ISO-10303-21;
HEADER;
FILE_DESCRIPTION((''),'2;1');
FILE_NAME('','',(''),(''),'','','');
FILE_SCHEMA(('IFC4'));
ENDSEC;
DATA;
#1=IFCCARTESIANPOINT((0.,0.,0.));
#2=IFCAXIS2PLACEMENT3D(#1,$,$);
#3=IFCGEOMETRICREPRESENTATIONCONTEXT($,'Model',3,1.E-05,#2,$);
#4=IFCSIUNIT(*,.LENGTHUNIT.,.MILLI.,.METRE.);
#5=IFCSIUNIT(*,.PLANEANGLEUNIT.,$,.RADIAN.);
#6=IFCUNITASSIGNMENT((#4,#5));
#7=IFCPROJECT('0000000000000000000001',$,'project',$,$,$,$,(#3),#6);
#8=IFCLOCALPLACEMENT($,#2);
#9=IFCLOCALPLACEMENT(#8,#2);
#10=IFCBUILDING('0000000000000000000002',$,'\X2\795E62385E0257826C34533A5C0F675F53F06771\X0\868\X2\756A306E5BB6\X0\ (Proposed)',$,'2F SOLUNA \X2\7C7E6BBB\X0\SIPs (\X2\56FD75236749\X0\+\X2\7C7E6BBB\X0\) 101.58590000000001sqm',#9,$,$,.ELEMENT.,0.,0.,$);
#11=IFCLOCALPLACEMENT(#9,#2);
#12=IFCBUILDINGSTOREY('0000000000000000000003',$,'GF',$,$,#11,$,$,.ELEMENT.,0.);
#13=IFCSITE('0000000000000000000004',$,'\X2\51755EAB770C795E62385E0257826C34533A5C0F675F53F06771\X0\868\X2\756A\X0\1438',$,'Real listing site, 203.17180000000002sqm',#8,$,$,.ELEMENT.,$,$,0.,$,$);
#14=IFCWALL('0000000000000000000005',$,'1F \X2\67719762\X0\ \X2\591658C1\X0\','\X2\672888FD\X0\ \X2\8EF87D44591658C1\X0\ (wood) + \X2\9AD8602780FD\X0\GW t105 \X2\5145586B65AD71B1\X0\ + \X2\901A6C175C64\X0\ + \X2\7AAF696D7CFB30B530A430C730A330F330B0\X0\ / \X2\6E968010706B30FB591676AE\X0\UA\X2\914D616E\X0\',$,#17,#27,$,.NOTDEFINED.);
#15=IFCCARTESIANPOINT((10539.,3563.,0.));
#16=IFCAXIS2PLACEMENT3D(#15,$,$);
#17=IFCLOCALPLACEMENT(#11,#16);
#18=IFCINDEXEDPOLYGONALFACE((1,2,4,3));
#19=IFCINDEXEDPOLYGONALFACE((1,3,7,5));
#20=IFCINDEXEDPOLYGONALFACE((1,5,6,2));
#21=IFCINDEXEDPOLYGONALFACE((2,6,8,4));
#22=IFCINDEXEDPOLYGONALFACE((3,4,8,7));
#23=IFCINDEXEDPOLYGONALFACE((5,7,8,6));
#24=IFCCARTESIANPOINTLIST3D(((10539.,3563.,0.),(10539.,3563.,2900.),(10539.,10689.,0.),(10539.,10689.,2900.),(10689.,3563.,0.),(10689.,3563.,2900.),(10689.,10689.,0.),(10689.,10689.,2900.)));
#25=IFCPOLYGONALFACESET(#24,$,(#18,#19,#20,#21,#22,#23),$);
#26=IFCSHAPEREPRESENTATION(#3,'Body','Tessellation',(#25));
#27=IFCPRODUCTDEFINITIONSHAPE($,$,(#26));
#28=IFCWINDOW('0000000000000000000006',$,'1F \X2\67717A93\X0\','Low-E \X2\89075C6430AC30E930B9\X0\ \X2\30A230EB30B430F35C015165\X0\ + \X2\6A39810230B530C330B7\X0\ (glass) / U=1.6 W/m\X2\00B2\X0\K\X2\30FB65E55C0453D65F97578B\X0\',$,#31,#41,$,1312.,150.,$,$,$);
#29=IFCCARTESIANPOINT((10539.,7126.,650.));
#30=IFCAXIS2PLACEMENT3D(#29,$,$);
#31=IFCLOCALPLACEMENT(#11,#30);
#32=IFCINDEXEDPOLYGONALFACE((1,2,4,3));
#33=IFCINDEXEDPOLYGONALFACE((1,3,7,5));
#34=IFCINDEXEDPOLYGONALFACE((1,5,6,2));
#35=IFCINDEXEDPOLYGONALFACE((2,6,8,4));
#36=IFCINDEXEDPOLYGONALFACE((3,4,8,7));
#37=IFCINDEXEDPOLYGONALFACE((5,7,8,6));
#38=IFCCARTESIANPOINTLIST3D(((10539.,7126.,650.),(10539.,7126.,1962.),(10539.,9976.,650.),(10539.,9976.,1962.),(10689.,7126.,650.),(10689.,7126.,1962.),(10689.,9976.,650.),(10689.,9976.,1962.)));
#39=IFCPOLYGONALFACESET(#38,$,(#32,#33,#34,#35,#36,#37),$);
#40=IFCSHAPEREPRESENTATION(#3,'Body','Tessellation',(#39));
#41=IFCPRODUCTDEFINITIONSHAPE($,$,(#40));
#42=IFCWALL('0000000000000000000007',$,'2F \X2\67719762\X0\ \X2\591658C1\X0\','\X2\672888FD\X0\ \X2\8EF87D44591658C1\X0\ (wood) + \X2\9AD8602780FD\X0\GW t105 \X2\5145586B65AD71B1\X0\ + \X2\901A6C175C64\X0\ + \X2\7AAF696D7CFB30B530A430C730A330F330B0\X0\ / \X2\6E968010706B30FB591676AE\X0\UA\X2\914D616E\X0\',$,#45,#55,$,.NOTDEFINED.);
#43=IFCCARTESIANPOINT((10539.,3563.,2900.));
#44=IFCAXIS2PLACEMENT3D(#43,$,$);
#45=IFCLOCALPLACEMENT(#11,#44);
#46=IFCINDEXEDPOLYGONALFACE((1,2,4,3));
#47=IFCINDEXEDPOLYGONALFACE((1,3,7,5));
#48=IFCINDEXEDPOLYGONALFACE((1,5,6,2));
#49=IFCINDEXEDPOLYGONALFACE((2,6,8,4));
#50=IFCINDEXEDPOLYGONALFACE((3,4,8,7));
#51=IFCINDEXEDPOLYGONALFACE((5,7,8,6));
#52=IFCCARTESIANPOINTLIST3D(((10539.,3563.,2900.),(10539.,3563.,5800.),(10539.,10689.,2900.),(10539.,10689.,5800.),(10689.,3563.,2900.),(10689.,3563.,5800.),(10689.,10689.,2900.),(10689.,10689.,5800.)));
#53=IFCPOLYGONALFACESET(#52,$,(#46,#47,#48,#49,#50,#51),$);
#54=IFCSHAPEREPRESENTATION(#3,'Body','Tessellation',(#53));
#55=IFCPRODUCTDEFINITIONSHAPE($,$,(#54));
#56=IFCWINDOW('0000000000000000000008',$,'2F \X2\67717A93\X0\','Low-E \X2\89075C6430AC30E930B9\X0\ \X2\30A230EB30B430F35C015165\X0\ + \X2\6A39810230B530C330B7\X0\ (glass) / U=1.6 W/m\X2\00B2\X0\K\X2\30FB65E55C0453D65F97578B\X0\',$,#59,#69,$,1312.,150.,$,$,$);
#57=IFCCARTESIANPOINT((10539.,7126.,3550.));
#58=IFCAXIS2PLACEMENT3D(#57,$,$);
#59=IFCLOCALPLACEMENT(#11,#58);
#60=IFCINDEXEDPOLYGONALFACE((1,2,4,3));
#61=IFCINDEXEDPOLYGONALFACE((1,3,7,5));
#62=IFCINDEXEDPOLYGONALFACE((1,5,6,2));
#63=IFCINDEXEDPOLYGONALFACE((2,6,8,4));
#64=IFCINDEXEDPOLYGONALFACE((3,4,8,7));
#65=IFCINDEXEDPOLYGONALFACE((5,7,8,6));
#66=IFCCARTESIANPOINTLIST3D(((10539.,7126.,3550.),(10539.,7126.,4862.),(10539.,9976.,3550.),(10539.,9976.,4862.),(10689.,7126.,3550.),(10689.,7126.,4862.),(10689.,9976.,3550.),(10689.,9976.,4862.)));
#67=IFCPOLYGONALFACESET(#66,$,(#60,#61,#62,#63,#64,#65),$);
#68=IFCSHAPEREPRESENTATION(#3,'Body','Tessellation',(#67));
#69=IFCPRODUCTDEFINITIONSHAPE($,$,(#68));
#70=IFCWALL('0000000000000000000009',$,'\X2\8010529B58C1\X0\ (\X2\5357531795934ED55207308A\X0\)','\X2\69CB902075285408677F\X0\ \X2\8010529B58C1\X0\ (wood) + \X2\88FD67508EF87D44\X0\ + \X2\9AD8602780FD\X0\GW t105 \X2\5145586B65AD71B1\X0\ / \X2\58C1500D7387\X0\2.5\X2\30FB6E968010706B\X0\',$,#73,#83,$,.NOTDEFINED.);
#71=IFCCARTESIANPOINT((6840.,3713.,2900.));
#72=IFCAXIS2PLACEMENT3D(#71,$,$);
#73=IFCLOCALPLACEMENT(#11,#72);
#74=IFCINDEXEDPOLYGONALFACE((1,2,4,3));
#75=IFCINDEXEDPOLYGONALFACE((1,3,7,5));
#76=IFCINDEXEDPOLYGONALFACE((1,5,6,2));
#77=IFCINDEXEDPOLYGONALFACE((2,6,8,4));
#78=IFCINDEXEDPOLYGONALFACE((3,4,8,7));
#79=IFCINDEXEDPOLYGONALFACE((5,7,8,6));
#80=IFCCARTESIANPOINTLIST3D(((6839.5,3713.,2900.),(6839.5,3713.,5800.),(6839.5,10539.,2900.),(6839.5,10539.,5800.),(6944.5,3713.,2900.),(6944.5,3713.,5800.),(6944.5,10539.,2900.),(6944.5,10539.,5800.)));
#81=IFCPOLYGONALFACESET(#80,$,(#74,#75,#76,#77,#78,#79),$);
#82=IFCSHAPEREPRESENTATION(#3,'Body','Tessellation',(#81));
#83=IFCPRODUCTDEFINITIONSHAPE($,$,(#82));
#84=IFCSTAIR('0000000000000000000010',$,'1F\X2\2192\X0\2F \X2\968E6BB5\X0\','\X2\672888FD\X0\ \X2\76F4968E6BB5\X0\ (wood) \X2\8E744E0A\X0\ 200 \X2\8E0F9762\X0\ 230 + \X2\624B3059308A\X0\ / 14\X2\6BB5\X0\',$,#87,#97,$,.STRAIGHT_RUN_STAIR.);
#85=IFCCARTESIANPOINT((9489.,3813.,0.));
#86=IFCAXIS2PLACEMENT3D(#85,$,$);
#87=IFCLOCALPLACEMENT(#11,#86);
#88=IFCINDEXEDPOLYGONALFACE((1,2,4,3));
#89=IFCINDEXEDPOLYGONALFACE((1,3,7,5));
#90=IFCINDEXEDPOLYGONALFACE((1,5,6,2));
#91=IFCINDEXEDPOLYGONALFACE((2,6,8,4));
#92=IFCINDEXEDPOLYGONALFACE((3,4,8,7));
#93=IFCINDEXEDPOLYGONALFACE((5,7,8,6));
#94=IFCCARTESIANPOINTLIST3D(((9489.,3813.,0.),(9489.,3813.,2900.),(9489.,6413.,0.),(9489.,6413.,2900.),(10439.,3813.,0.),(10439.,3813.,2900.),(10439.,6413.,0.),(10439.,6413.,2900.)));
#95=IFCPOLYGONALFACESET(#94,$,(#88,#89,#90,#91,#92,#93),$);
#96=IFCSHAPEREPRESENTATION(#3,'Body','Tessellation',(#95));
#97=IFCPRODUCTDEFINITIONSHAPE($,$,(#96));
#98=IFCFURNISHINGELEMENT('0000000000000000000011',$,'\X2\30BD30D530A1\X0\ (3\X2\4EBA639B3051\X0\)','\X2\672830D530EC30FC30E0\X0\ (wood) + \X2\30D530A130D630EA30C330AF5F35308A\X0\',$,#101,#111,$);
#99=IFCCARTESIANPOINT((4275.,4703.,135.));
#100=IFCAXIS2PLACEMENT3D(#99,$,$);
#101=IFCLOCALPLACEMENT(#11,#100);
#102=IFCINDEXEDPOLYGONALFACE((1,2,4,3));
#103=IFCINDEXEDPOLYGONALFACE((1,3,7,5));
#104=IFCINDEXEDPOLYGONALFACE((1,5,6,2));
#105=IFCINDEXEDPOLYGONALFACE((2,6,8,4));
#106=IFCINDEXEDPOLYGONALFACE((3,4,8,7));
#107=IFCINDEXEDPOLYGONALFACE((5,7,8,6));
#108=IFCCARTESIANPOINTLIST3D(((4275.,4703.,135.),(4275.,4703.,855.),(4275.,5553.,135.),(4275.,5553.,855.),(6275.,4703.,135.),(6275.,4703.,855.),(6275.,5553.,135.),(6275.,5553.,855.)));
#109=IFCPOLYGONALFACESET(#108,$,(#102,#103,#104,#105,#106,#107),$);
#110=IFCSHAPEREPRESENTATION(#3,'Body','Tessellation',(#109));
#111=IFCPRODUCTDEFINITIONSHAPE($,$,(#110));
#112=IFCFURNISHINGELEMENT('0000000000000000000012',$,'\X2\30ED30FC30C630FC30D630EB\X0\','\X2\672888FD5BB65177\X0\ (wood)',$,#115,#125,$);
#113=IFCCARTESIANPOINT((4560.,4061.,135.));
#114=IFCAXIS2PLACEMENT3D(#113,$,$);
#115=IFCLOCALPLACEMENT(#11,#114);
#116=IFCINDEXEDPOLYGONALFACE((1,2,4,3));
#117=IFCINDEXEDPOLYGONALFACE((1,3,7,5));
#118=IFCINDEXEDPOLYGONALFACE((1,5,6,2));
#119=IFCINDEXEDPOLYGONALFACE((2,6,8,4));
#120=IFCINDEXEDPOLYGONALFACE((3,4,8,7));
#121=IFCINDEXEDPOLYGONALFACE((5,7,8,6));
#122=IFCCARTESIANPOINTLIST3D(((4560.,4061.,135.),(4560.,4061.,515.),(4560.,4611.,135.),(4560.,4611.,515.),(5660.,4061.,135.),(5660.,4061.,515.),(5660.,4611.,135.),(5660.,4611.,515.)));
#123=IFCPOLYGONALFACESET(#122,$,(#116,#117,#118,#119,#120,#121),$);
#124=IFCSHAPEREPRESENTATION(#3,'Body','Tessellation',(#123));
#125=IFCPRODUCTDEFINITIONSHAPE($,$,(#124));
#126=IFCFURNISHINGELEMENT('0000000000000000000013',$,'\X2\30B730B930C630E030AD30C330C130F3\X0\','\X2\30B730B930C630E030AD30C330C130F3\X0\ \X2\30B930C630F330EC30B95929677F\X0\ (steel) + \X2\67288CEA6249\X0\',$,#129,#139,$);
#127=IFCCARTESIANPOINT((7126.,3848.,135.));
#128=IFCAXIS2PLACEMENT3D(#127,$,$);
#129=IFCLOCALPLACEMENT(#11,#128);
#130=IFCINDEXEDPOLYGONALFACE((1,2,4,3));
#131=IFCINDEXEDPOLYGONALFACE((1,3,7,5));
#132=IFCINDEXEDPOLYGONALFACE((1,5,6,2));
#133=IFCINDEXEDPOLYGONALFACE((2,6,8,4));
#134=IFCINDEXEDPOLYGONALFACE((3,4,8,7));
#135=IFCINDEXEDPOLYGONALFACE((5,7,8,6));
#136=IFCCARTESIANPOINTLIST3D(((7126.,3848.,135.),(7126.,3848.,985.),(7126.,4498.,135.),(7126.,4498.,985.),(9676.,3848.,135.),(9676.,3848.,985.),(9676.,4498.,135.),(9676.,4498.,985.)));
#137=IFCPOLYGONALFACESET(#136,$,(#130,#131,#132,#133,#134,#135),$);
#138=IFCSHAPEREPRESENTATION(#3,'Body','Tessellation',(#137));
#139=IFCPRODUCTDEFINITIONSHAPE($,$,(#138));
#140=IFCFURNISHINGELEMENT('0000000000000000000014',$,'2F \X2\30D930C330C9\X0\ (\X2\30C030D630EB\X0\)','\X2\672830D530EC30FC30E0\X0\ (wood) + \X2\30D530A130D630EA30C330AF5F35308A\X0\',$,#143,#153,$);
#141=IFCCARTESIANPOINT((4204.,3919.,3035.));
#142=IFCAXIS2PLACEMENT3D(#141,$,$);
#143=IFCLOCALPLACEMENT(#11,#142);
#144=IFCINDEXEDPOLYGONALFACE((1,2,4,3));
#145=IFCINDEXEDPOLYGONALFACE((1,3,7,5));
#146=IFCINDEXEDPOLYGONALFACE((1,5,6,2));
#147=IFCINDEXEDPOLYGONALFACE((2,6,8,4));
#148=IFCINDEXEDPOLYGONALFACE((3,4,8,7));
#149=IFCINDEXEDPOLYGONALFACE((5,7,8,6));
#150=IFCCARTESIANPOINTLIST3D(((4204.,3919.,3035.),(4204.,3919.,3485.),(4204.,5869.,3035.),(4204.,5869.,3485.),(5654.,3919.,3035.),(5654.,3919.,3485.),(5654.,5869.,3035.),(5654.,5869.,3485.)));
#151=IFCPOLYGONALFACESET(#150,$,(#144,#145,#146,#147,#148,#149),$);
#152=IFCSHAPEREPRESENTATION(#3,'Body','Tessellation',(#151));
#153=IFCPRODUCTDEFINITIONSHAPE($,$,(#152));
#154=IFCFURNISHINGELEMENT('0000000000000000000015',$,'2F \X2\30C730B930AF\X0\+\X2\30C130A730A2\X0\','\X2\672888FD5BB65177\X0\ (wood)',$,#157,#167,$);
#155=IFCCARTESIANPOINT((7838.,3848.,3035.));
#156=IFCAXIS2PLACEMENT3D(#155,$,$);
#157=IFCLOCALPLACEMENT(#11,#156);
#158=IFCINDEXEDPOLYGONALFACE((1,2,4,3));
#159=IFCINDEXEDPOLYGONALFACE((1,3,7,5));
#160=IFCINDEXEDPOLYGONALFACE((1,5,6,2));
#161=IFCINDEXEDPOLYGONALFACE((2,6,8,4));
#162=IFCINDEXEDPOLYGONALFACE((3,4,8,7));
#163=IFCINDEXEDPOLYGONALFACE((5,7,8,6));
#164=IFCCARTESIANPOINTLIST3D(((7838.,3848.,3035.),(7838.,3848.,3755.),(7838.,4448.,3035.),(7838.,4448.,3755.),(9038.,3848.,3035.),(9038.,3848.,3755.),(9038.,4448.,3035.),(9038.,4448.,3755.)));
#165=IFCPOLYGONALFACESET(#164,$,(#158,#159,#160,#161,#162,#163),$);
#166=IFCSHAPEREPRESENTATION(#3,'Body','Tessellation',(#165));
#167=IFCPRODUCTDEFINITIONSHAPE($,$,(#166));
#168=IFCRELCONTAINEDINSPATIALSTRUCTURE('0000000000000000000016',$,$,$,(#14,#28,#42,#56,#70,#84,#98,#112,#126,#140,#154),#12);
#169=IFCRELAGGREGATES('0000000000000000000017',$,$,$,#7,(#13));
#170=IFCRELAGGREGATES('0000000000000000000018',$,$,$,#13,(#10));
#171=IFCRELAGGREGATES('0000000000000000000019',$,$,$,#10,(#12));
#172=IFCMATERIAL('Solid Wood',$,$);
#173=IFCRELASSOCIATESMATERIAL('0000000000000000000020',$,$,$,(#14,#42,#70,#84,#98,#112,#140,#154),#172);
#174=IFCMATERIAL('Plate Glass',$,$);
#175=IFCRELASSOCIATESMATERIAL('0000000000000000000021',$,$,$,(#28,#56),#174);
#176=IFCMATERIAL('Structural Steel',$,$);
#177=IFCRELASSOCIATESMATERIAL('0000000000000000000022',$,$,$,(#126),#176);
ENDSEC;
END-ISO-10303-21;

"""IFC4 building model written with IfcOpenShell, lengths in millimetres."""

from ifc_helpers import new_model, si_unit, frame, frame_2d, origin, place, context, project, spatial, rectangle, extrude, material, element, fill, save


model = new_model("IFC4")

# Units and contexts
model_context = context("Model", 3, precision=1e-05, world=origin())
ifc_project = project(units=[si_unit("LENGTHUNIT", "METRE", prefix="MILLI"), si_unit("PLANEANGLEUNIT", "RADIAN")], contexts=[model_context])

# Site, building, storey
site_placement = place(None, origin())
site = spatial("IfcSite", under=ifc_project, at=site_placement, Name="兵庫県神戸市垂水区小束台東868番1438", ObjectType="Real listing site, 203.17180000000002sqm", CompositionType="ELEMENT", RefElevation=0.0)
building_placement = place(site_placement, origin())
building = spatial("IfcBuilding", under=site, at=building_placement, Name="神戸市垂水区小束台東868番の家 (Proposed)", ObjectType="2F SOLUNA 籾殻SIPs (国産杉+籾殻) 101.58590000000001sqm", CompositionType="ELEMENT", ElevationOfRefHeight=0.0, ElevationOfTerrain=0.0)
storey_placement = place(building_placement, origin())
storey = spatial("IfcBuildingStorey", under=building, at=storey_placement, Name="GF", CompositionType="ELEMENT", Elevation=0.0)

# Wall, opening, window
ifc_material_1 = material(Name="Solid Wood")
wall_1_placement = place(storey_placement, frame((10539.0, 3563.0, 0.0)))
wall_1 = element("IfcWall", 1, at=wall_1_placement, inside=storey, material=ifc_material_1, Name="1F 東面 外壁", Description="木製 軸組外壁 (wood) + 高性能GW t105 充填断熱 + 通気層 + 窯業系サイディング / 準耐火・外皮UA配慮", PredefinedType="NOTDEFINED", context=model_context, shape_type="SweptSolid", body=[
    extrude(rectangle(XDim=150.0, YDim=7126.0, at=frame_2d((75.0, 3563.0))), frame((10539.0, 3563.0, 0.0)), (0.0, 0.0, 1.0), 2900.0),
])
opening_1_placement = place(storey_placement, frame((10539.0, 7126.0, 650.0)))
opening_1 = element("IfcOpeningElement", 2, at=opening_1_placement, cuts=wall_1, PredefinedType="NOTDEFINED", context=model_context, shape_type="SweptSolid", body=[
    extrude(rectangle(XDim=150.0, YDim=2850.0, at=frame_2d((75.0, 1425.0))), frame((10539.0, 7126.0, 650.0)), (0.0, 0.0, 1.0), 1312.0),
])
ifc_material_2 = material(Name="Plate Glass")
window_1_placement = place(storey_placement, frame((10539.0, 7126.0, 650.0)))
window_1 = element("IfcWindow", 3, at=window_1_placement, inside=storey, material=ifc_material_2, Name="1F 東窓", Description="Low-E 複層ガラス アルゴン封入 + 樹脂サッシ (glass) / U=1.6 W/m²K・日射取得型", OverallHeight=1312.0, OverallWidth=150.0, context=model_context, shape_type="SweptSolid", body=[
    extrude(rectangle(XDim=150.0, YDim=2850.0, at=frame_2d((75.0, 1425.0))), frame((10539.0, 7126.0, 650.0)), (0.0, 0.0, 1.0), 1312.0),
])
fill(opening_1, window_1)

# Wall, opening, window
wall_2_placement = place(storey_placement, frame((10539.0, 3563.0, 2900.0)))
wall_2 = element("IfcWall", 4, at=wall_2_placement, inside=storey, material=ifc_material_1, Name="2F 東面 外壁", Description="木製 軸組外壁 (wood) + 高性能GW t105 充填断熱 + 通気層 + 窯業系サイディング / 準耐火・外皮UA配慮", PredefinedType="NOTDEFINED", context=model_context, shape_type="SweptSolid", body=[
    extrude(rectangle(XDim=150.0, YDim=7126.0, at=frame_2d((75.0, 3563.0))), frame((10539.0, 3563.0, 2900.0)), (0.0, 0.0, 1.0), 2900.0),
])
opening_2_placement = place(storey_placement, frame((10539.0, 7126.0, 3550.0)))
opening_2 = element("IfcOpeningElement", 5, at=opening_2_placement, cuts=wall_2, PredefinedType="NOTDEFINED", context=model_context, shape_type="SweptSolid", body=[
    extrude(rectangle(XDim=150.0, YDim=2850.0, at=frame_2d((75.0, 1425.0))), frame((10539.0, 7126.0, 3550.0)), (0.0, 0.0, 1.0), 1312.0),
])
window_2_placement = place(storey_placement, frame((10539.0, 7126.0, 3550.0)))
window_2 = element("IfcWindow", 6, at=window_2_placement, inside=storey, material=ifc_material_2, Name="2F 東窓", Description="Low-E 複層ガラス アルゴン封入 + 樹脂サッシ (glass) / U=1.6 W/m²K・日射取得型", OverallHeight=1312.0, OverallWidth=150.0, context=model_context, shape_type="SweptSolid", body=[
    extrude(rectangle(XDim=150.0, YDim=2850.0, at=frame_2d((75.0, 1425.0))), frame((10539.0, 7126.0, 3550.0)), (0.0, 0.0, 1.0), 1312.0),
])
fill(opening_2, window_2)

# Wall
wall_3_placement = place(storey_placement, frame((6840.0, 3713.0, 2900.0)))
element("IfcWall", 7, at=wall_3_placement, inside=storey, material=ifc_material_1, Name="耐力壁 (南北間仕切り)", Description="構造用合板 耐力壁 (wood) + 製材軸組 + 高性能GW t105 充填断熱 / 壁倍率2.5・準耐火", PredefinedType="NOTDEFINED", context=model_context, shape_type="SweptSolid", body=[
    extrude(rectangle(XDim=105.0, YDim=6826.0, at=frame_2d((52.0, 3413.0))), frame((6840.0, 3713.0, 2900.0)), (0.0, 0.0, 1.0), 2900.0),
])

# Stair
stair_placement = place(storey_placement, frame((9489.0, 3813.0, 0.0)))
element("IfcStair", 8, at=stair_placement, inside=storey, material=ifc_material_1, Name="1F→2F 階段", Description="木製 直階段 (wood) 蹴上 200 踏面 230 + 手すり / 14段", PredefinedType="STRAIGHT_RUN_STAIR", context=model_context, shape_type="SweptSolid", body=[
    extrude(rectangle(XDim=950.0, YDim=2600.0, at=frame_2d((475.0, 1300.0))), frame((9489.0, 3813.0, 0.0)), (0.0, 0.0, 1.0), 2900.0),
])

# Furnishing elements
furnishing_1_placement = place(storey_placement, frame((4275.0, 4703.0, 135.0)))
element("IfcFurnishingElement", 9, at=furnishing_1_placement, inside=storey, material=ifc_material_1, Name="ソファ (3人掛け)", Description="木フレーム (wood) + ファブリック張り", context=model_context, shape_type="SweptSolid", body=[
    extrude(rectangle(XDim=2000.0, YDim=850.0, at=frame_2d((1000.0, 425.0))), frame((4275.0, 4703.0, 135.0)), (0.0, 0.0, 1.0), 720.0),
])
furnishing_2_placement = place(storey_placement, frame((4560.0, 4061.0, 135.0)))
element("IfcFurnishingElement", 10, at=furnishing_2_placement, inside=storey, material=ifc_material_1, Name="ローテーブル", Description="木製家具 (wood)", context=model_context, shape_type="SweptSolid", body=[
    extrude(rectangle(XDim=1100.0, YDim=550.0, at=frame_2d((550.0, 275.0))), frame((4560.0, 4061.0, 135.0)), (0.0, 0.0, 1.0), 380.0),
])
ifc_material_3 = material(Name="Structural Steel")
furnishing_3_placement = place(storey_placement, frame((7126.0, 3848.0, 135.0)))
element("IfcFurnishingElement", 11, at=furnishing_3_placement, inside=storey, material=ifc_material_3, Name="システムキッチン", Description="システムキッチン ステンレス天板 (steel) + 木質扉", context=model_context, shape_type="SweptSolid", body=[
    extrude(rectangle(XDim=2550.0, YDim=650.0, at=frame_2d((1275.0, 325.0))), frame((7126.0, 3848.0, 135.0)), (0.0, 0.0, 1.0), 850.0),
])
furnishing_4_placement = place(storey_placement, frame((4204.0, 3919.0, 3035.0)))
element("IfcFurnishingElement", 12, at=furnishing_4_placement, inside=storey, material=ifc_material_1, Name="2F ベッド (ダブル)", Description="木フレーム (wood) + ファブリック張り", context=model_context, shape_type="SweptSolid", body=[
    extrude(rectangle(XDim=1450.0, YDim=1950.0, at=frame_2d((725.0, 975.0))), frame((4204.0, 3919.0, 3035.0)), (0.0, 0.0, 1.0), 450.0),
])
furnishing_5_placement = place(storey_placement, frame((7838.0, 3848.0, 3035.0)))
element("IfcFurnishingElement", 13, at=furnishing_5_placement, inside=storey, material=ifc_material_1, Name="2F デスク+チェア", Description="木製家具 (wood)", context=model_context, shape_type="SweptSolid", body=[
    extrude(rectangle(XDim=1200.0, YDim=600.0, at=frame_2d((600.0, 300.0))), frame((7838.0, 3848.0, 3035.0)), (0.0, 0.0, 1.0), 720.0),
])

save(model, "model.ifc")
